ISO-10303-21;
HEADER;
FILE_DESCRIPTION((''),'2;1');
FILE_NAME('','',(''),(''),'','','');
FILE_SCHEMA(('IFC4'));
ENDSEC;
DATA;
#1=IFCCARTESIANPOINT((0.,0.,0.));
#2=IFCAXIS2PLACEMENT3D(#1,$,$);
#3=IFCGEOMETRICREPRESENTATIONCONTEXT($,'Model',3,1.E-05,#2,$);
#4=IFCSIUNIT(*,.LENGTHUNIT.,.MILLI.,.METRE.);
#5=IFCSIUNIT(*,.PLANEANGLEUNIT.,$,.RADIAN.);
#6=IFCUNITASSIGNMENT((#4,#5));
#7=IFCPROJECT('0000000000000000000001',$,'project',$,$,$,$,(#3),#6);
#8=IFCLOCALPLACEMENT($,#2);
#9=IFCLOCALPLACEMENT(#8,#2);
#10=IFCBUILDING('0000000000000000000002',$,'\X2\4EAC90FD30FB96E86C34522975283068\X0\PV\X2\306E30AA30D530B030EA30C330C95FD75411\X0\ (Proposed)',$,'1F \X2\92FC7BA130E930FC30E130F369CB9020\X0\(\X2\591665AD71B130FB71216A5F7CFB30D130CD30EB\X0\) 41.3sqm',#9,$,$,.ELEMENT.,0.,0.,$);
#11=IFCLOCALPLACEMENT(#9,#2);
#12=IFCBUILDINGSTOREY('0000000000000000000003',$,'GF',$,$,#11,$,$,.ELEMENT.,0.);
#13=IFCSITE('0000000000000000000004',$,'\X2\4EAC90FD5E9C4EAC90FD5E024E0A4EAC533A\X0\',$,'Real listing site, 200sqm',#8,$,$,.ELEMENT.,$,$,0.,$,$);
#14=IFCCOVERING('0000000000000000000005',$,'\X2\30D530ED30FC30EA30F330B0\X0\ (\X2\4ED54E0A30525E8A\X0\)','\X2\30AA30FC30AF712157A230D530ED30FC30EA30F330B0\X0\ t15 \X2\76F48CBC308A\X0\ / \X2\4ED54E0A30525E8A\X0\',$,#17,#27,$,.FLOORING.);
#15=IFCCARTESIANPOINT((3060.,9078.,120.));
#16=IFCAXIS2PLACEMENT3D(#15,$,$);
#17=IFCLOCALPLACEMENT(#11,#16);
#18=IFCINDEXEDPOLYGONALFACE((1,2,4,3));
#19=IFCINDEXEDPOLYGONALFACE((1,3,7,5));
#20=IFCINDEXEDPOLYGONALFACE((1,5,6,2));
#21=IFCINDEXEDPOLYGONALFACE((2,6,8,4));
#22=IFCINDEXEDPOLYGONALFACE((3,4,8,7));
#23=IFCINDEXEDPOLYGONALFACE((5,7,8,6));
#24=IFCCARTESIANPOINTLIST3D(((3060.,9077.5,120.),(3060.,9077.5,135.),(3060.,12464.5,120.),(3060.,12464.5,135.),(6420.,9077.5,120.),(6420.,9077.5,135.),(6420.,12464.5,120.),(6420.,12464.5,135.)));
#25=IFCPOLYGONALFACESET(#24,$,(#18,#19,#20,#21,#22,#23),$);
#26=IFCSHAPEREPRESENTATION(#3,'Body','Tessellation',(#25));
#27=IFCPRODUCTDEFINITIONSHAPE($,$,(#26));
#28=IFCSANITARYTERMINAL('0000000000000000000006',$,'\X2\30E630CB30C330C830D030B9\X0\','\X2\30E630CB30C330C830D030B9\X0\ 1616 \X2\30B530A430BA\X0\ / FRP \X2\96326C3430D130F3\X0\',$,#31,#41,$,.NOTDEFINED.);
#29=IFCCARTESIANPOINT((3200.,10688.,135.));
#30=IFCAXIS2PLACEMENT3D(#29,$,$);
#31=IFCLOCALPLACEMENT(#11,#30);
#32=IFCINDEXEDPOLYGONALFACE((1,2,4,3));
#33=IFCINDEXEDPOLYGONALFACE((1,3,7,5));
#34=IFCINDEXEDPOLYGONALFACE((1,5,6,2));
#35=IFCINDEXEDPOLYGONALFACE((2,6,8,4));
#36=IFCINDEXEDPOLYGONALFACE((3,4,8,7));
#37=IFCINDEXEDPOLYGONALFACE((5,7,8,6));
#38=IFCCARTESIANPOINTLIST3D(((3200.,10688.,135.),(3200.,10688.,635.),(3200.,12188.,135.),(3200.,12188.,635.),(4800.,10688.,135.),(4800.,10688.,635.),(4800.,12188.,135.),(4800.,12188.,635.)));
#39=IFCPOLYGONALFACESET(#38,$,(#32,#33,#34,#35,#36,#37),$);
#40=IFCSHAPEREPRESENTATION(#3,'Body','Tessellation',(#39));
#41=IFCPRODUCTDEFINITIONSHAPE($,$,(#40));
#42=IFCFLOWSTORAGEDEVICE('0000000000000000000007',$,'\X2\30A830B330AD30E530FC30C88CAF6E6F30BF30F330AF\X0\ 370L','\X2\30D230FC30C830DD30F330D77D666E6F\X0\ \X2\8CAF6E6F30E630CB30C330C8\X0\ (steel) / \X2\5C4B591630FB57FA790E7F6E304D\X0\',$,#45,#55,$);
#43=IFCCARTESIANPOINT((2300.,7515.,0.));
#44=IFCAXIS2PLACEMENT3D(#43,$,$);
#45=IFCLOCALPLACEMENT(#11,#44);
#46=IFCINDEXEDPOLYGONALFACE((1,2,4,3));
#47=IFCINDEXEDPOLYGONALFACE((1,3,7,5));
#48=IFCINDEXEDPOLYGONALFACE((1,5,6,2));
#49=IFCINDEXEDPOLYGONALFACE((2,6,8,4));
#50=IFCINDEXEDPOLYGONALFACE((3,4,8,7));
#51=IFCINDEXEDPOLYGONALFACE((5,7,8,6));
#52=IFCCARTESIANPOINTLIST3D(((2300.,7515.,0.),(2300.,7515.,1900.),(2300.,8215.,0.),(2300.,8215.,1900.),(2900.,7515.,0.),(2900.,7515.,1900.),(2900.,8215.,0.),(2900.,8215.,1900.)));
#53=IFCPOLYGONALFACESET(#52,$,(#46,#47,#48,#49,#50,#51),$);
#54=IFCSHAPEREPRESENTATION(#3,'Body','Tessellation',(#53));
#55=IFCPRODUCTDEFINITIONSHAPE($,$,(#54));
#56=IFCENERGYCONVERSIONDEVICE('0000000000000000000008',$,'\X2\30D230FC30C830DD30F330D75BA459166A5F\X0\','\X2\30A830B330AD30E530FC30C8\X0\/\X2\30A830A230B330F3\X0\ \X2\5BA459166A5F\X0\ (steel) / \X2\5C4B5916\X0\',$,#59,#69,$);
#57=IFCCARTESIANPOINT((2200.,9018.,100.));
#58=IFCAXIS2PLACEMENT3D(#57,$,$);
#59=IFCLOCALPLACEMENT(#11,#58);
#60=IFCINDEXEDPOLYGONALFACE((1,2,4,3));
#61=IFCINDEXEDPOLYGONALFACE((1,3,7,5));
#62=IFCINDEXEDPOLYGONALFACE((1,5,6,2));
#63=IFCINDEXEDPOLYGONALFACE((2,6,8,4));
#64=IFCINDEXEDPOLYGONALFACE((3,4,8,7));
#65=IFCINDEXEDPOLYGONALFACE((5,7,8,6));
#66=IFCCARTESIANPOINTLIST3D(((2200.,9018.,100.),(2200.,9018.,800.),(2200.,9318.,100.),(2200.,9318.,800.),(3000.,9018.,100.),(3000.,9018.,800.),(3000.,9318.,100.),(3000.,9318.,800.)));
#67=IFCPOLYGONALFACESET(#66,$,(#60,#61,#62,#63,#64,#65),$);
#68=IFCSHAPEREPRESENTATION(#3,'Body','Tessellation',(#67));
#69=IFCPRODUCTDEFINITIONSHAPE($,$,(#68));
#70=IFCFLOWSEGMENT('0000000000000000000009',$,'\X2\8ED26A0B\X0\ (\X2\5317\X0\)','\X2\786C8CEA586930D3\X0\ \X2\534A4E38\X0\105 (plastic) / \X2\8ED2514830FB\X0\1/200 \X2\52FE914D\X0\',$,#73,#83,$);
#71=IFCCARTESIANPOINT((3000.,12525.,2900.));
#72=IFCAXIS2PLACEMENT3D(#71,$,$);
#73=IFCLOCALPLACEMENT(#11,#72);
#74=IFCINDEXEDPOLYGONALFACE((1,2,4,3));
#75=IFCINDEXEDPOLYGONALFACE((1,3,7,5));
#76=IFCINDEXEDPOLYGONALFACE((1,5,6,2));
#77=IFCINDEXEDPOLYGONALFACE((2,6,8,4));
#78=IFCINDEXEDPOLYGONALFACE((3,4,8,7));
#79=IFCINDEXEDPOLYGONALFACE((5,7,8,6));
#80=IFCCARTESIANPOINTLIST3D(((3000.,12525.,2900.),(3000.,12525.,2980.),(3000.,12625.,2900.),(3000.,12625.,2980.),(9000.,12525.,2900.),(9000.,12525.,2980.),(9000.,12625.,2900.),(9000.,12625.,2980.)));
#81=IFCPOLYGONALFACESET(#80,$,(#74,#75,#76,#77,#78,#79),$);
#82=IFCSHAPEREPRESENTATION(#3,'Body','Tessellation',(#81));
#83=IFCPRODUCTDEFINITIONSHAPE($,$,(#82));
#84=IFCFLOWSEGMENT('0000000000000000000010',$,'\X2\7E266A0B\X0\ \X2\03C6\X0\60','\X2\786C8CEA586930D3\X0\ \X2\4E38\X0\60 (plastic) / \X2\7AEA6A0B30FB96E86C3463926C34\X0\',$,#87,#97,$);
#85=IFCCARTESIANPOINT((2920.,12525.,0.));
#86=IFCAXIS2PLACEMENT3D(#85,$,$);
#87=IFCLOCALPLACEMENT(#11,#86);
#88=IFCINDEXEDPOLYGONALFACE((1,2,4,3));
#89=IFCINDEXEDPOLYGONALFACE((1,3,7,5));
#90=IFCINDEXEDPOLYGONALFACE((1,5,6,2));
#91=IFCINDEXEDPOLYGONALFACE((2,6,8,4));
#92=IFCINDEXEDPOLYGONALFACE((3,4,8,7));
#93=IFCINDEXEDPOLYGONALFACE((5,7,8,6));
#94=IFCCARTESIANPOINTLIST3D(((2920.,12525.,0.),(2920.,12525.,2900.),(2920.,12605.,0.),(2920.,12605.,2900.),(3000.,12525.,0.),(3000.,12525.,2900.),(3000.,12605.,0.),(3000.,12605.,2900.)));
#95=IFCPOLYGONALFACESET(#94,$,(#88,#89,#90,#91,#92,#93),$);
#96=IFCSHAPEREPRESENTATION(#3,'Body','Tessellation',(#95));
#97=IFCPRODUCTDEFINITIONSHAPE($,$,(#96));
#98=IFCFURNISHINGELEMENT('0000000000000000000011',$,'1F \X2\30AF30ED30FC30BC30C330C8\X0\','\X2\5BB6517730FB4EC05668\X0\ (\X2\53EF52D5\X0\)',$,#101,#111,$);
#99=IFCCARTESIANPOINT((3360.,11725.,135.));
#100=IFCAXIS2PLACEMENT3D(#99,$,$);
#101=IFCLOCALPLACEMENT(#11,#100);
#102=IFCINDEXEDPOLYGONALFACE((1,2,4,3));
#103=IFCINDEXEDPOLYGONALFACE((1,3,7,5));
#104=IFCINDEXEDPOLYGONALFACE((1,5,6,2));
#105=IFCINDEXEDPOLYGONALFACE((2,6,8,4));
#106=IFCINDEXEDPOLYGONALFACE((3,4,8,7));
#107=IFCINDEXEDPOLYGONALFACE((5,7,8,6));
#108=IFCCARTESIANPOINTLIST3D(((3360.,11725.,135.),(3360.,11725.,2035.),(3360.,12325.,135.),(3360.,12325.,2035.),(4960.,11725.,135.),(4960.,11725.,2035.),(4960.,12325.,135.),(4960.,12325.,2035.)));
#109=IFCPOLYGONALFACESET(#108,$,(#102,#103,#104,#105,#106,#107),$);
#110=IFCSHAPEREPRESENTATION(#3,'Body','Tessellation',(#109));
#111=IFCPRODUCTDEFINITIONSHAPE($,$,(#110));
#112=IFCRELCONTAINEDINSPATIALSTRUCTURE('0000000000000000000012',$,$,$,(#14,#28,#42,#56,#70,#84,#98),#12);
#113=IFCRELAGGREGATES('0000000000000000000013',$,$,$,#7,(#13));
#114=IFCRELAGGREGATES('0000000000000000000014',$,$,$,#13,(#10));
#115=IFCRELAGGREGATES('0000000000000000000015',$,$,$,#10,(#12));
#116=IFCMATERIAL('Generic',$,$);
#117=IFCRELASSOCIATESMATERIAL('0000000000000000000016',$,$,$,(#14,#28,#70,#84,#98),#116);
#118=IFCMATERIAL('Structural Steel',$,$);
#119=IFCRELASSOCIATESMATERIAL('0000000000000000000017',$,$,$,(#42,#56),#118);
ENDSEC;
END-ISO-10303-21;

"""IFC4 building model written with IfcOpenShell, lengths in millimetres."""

from ifc_helpers import new_model, si_unit, frame, frame_2d, origin, place, context, project, spatial, rectangle, extrude, material, element, save


model = new_model("IFC4")

# Units and contexts
model_context = context("Model", 3, precision=1e-05, world=origin())
ifc_project = project(units=[si_unit("LENGTHUNIT", "METRE", prefix="MILLI"), si_unit("PLANEANGLEUNIT", "RADIAN")], contexts=[model_context])

# Site, building, storey
site_placement = place(None, origin())
site = spatial("IfcSite", under=ifc_project, at=site_placement, Name="京都府京都市上京区", ObjectType="Real listing site, 200sqm", CompositionType="ELEMENT", RefElevation=0.0)
building_placement = place(site_placement, origin())
building = spatial("IfcBuilding", under=site, at=building_placement, Name="京都・雨水利用とPVのオフグリッド志向 (Proposed)", ObjectType="1F 鋼管ラーメン構造(外断熱・無機系パネル) 41.3sqm", CompositionType="ELEMENT", ElevationOfRefHeight=0.0, ElevationOfTerrain=0.0)
storey_placement = place(building_placement, origin())
storey = spatial("IfcBuildingStorey", under=building, at=storey_placement, Name="GF", CompositionType="ELEMENT", Elevation=0.0)

# Shared definitions
ifc_material_1 = material(Name="Structural Steel")

# Covering
ifc_material_2 = material(Name="Generic")
covering_placement = place(storey_placement, frame((3060.0, 9078.0, 120.0)))
element("IfcCovering", 1, at=covering_placement, inside=storey, material=ifc_material_2, Name="フローリング (仕上げ床)", Description="オーク無垢フローリング t15 直貼り / 仕上げ床", PredefinedType="FLOORING", context=model_context, shape_type="SweptSolid", body=[
    extrude(rectangle(XDim=3360.0, YDim=3387.0, at=frame_2d((1680.0, 1693.0))), frame((3060.0, 9078.0, 120.0)), (0.0, 0.0, 1.0), 15.0),
])

# Sanitary terminal
sanitary_terminal_placement = place(storey_placement, frame((3200.0, 10688.0, 135.0)))
element("IfcSanitaryTerminal", 2, at=sanitary_terminal_placement, inside=storey, material=ifc_material_2, Name="ユニットバス", Description="ユニットバス 1616 サイズ / FRP 防水パン", PredefinedType="NOTDEFINED", context=model_context, shape_type="SweptSolid", body=[
    extrude(rectangle(XDim=1600.0, YDim=1500.0, at=frame_2d((800.0, 750.0))), frame((3200.0, 10688.0, 135.0)), (0.0, 0.0, 1.0), 500.0),
])

# Flow storage device
flow_storage_device_placement = place(storey_placement, frame((2300.0, 7515.0, 0.0)))
element("IfcFlowStorageDevice", 3, at=flow_storage_device_placement, inside=storey, material=ifc_material_1, Name="エコキュート貯湯タンク 370L", Description="ヒートポンプ給湯 貯湯ユニット (steel) / 屋外・基礎置き", context=model_context, shape_type="SweptSolid", body=[
    extrude(rectangle(XDim=600.0, YDim=700.0, at=frame_2d((300.0, 350.0))), frame((2300.0, 7515.0, 0.0)), (0.0, 0.0, 1.0), 1900.0),
])

# Energy conversion device
energy_conversion_device_placement = place(storey_placement, frame((2200.0, 9018.0, 100.0)))
element("IfcEnergyConversionDevice", 4, at=energy_conversion_device_placement, inside=storey, material=ifc_material_1, Name="ヒートポンプ室外機", Description="エコキュート/エアコン 室外機 (steel) / 屋外", context=model_context, shape_type="SweptSolid", body=[
    extrude(rectangle(XDim=800.0, YDim=300.0, at=frame_2d((400.0, 150.0))), frame((2200.0, 9018.0, 100.0)), (0.0, 0.0, 1.0), 700.0),
])

# Flow segments
flow_segment_1_placement = place(storey_placement, frame((3000.0, 12525.0, 2900.0)))
element("IfcFlowSegment", 5, at=flow_segment_1_placement, inside=storey, material=ifc_material_2, Name="軒樋 (北)", Description="硬質塩ビ 半丸105 (plastic) / 軒先・1/200 勾配", context=model_context, shape_type="SweptSolid", body=[
    extrude(rectangle(XDim=6000.0, YDim=100.0, at=frame_2d((3000.0, 50.0))), frame((3000.0, 12525.0, 2900.0)), (0.0, 0.0, 1.0), 80.0),
])
flow_segment_2_placement = place(storey_placement, frame((2920.0, 12525.0, 0.0)))
element("IfcFlowSegment", 6, at=flow_segment_2_placement, inside=storey, material=ifc_material_2, Name="縦樋 φ60", Description="硬質塩ビ 丸60 (plastic) / 竪樋・雨水排水", context=model_context, shape_type="SweptSolid", body=[
    extrude(rectangle(XDim=80.0, YDim=80.0, at=frame_2d((40.0, 40.0))), frame((2920.0, 12525.0, 0.0)), (0.0, 0.0, 1.0), 2900.0),
])

# Furnishing element
furnishing_placement = place(storey_placement, frame((3360.0, 11725.0, 135.0)))
element("IfcFurnishingElement", 7, at=furnishing_placement, inside=storey, material=ifc_material_2, Name="1F クローゼット", Description="家具・什器 (可動)", context=model_context, shape_type="SweptSolid", body=[
    extrude(rectangle(XDim=1600.0, YDim=600.0, at=frame_2d((800.0, 300.0))), frame((3360.0, 11725.0, 135.0)), (0.0, 0.0, 1.0), 1900.0),
])

save(model, "model.ifc")
